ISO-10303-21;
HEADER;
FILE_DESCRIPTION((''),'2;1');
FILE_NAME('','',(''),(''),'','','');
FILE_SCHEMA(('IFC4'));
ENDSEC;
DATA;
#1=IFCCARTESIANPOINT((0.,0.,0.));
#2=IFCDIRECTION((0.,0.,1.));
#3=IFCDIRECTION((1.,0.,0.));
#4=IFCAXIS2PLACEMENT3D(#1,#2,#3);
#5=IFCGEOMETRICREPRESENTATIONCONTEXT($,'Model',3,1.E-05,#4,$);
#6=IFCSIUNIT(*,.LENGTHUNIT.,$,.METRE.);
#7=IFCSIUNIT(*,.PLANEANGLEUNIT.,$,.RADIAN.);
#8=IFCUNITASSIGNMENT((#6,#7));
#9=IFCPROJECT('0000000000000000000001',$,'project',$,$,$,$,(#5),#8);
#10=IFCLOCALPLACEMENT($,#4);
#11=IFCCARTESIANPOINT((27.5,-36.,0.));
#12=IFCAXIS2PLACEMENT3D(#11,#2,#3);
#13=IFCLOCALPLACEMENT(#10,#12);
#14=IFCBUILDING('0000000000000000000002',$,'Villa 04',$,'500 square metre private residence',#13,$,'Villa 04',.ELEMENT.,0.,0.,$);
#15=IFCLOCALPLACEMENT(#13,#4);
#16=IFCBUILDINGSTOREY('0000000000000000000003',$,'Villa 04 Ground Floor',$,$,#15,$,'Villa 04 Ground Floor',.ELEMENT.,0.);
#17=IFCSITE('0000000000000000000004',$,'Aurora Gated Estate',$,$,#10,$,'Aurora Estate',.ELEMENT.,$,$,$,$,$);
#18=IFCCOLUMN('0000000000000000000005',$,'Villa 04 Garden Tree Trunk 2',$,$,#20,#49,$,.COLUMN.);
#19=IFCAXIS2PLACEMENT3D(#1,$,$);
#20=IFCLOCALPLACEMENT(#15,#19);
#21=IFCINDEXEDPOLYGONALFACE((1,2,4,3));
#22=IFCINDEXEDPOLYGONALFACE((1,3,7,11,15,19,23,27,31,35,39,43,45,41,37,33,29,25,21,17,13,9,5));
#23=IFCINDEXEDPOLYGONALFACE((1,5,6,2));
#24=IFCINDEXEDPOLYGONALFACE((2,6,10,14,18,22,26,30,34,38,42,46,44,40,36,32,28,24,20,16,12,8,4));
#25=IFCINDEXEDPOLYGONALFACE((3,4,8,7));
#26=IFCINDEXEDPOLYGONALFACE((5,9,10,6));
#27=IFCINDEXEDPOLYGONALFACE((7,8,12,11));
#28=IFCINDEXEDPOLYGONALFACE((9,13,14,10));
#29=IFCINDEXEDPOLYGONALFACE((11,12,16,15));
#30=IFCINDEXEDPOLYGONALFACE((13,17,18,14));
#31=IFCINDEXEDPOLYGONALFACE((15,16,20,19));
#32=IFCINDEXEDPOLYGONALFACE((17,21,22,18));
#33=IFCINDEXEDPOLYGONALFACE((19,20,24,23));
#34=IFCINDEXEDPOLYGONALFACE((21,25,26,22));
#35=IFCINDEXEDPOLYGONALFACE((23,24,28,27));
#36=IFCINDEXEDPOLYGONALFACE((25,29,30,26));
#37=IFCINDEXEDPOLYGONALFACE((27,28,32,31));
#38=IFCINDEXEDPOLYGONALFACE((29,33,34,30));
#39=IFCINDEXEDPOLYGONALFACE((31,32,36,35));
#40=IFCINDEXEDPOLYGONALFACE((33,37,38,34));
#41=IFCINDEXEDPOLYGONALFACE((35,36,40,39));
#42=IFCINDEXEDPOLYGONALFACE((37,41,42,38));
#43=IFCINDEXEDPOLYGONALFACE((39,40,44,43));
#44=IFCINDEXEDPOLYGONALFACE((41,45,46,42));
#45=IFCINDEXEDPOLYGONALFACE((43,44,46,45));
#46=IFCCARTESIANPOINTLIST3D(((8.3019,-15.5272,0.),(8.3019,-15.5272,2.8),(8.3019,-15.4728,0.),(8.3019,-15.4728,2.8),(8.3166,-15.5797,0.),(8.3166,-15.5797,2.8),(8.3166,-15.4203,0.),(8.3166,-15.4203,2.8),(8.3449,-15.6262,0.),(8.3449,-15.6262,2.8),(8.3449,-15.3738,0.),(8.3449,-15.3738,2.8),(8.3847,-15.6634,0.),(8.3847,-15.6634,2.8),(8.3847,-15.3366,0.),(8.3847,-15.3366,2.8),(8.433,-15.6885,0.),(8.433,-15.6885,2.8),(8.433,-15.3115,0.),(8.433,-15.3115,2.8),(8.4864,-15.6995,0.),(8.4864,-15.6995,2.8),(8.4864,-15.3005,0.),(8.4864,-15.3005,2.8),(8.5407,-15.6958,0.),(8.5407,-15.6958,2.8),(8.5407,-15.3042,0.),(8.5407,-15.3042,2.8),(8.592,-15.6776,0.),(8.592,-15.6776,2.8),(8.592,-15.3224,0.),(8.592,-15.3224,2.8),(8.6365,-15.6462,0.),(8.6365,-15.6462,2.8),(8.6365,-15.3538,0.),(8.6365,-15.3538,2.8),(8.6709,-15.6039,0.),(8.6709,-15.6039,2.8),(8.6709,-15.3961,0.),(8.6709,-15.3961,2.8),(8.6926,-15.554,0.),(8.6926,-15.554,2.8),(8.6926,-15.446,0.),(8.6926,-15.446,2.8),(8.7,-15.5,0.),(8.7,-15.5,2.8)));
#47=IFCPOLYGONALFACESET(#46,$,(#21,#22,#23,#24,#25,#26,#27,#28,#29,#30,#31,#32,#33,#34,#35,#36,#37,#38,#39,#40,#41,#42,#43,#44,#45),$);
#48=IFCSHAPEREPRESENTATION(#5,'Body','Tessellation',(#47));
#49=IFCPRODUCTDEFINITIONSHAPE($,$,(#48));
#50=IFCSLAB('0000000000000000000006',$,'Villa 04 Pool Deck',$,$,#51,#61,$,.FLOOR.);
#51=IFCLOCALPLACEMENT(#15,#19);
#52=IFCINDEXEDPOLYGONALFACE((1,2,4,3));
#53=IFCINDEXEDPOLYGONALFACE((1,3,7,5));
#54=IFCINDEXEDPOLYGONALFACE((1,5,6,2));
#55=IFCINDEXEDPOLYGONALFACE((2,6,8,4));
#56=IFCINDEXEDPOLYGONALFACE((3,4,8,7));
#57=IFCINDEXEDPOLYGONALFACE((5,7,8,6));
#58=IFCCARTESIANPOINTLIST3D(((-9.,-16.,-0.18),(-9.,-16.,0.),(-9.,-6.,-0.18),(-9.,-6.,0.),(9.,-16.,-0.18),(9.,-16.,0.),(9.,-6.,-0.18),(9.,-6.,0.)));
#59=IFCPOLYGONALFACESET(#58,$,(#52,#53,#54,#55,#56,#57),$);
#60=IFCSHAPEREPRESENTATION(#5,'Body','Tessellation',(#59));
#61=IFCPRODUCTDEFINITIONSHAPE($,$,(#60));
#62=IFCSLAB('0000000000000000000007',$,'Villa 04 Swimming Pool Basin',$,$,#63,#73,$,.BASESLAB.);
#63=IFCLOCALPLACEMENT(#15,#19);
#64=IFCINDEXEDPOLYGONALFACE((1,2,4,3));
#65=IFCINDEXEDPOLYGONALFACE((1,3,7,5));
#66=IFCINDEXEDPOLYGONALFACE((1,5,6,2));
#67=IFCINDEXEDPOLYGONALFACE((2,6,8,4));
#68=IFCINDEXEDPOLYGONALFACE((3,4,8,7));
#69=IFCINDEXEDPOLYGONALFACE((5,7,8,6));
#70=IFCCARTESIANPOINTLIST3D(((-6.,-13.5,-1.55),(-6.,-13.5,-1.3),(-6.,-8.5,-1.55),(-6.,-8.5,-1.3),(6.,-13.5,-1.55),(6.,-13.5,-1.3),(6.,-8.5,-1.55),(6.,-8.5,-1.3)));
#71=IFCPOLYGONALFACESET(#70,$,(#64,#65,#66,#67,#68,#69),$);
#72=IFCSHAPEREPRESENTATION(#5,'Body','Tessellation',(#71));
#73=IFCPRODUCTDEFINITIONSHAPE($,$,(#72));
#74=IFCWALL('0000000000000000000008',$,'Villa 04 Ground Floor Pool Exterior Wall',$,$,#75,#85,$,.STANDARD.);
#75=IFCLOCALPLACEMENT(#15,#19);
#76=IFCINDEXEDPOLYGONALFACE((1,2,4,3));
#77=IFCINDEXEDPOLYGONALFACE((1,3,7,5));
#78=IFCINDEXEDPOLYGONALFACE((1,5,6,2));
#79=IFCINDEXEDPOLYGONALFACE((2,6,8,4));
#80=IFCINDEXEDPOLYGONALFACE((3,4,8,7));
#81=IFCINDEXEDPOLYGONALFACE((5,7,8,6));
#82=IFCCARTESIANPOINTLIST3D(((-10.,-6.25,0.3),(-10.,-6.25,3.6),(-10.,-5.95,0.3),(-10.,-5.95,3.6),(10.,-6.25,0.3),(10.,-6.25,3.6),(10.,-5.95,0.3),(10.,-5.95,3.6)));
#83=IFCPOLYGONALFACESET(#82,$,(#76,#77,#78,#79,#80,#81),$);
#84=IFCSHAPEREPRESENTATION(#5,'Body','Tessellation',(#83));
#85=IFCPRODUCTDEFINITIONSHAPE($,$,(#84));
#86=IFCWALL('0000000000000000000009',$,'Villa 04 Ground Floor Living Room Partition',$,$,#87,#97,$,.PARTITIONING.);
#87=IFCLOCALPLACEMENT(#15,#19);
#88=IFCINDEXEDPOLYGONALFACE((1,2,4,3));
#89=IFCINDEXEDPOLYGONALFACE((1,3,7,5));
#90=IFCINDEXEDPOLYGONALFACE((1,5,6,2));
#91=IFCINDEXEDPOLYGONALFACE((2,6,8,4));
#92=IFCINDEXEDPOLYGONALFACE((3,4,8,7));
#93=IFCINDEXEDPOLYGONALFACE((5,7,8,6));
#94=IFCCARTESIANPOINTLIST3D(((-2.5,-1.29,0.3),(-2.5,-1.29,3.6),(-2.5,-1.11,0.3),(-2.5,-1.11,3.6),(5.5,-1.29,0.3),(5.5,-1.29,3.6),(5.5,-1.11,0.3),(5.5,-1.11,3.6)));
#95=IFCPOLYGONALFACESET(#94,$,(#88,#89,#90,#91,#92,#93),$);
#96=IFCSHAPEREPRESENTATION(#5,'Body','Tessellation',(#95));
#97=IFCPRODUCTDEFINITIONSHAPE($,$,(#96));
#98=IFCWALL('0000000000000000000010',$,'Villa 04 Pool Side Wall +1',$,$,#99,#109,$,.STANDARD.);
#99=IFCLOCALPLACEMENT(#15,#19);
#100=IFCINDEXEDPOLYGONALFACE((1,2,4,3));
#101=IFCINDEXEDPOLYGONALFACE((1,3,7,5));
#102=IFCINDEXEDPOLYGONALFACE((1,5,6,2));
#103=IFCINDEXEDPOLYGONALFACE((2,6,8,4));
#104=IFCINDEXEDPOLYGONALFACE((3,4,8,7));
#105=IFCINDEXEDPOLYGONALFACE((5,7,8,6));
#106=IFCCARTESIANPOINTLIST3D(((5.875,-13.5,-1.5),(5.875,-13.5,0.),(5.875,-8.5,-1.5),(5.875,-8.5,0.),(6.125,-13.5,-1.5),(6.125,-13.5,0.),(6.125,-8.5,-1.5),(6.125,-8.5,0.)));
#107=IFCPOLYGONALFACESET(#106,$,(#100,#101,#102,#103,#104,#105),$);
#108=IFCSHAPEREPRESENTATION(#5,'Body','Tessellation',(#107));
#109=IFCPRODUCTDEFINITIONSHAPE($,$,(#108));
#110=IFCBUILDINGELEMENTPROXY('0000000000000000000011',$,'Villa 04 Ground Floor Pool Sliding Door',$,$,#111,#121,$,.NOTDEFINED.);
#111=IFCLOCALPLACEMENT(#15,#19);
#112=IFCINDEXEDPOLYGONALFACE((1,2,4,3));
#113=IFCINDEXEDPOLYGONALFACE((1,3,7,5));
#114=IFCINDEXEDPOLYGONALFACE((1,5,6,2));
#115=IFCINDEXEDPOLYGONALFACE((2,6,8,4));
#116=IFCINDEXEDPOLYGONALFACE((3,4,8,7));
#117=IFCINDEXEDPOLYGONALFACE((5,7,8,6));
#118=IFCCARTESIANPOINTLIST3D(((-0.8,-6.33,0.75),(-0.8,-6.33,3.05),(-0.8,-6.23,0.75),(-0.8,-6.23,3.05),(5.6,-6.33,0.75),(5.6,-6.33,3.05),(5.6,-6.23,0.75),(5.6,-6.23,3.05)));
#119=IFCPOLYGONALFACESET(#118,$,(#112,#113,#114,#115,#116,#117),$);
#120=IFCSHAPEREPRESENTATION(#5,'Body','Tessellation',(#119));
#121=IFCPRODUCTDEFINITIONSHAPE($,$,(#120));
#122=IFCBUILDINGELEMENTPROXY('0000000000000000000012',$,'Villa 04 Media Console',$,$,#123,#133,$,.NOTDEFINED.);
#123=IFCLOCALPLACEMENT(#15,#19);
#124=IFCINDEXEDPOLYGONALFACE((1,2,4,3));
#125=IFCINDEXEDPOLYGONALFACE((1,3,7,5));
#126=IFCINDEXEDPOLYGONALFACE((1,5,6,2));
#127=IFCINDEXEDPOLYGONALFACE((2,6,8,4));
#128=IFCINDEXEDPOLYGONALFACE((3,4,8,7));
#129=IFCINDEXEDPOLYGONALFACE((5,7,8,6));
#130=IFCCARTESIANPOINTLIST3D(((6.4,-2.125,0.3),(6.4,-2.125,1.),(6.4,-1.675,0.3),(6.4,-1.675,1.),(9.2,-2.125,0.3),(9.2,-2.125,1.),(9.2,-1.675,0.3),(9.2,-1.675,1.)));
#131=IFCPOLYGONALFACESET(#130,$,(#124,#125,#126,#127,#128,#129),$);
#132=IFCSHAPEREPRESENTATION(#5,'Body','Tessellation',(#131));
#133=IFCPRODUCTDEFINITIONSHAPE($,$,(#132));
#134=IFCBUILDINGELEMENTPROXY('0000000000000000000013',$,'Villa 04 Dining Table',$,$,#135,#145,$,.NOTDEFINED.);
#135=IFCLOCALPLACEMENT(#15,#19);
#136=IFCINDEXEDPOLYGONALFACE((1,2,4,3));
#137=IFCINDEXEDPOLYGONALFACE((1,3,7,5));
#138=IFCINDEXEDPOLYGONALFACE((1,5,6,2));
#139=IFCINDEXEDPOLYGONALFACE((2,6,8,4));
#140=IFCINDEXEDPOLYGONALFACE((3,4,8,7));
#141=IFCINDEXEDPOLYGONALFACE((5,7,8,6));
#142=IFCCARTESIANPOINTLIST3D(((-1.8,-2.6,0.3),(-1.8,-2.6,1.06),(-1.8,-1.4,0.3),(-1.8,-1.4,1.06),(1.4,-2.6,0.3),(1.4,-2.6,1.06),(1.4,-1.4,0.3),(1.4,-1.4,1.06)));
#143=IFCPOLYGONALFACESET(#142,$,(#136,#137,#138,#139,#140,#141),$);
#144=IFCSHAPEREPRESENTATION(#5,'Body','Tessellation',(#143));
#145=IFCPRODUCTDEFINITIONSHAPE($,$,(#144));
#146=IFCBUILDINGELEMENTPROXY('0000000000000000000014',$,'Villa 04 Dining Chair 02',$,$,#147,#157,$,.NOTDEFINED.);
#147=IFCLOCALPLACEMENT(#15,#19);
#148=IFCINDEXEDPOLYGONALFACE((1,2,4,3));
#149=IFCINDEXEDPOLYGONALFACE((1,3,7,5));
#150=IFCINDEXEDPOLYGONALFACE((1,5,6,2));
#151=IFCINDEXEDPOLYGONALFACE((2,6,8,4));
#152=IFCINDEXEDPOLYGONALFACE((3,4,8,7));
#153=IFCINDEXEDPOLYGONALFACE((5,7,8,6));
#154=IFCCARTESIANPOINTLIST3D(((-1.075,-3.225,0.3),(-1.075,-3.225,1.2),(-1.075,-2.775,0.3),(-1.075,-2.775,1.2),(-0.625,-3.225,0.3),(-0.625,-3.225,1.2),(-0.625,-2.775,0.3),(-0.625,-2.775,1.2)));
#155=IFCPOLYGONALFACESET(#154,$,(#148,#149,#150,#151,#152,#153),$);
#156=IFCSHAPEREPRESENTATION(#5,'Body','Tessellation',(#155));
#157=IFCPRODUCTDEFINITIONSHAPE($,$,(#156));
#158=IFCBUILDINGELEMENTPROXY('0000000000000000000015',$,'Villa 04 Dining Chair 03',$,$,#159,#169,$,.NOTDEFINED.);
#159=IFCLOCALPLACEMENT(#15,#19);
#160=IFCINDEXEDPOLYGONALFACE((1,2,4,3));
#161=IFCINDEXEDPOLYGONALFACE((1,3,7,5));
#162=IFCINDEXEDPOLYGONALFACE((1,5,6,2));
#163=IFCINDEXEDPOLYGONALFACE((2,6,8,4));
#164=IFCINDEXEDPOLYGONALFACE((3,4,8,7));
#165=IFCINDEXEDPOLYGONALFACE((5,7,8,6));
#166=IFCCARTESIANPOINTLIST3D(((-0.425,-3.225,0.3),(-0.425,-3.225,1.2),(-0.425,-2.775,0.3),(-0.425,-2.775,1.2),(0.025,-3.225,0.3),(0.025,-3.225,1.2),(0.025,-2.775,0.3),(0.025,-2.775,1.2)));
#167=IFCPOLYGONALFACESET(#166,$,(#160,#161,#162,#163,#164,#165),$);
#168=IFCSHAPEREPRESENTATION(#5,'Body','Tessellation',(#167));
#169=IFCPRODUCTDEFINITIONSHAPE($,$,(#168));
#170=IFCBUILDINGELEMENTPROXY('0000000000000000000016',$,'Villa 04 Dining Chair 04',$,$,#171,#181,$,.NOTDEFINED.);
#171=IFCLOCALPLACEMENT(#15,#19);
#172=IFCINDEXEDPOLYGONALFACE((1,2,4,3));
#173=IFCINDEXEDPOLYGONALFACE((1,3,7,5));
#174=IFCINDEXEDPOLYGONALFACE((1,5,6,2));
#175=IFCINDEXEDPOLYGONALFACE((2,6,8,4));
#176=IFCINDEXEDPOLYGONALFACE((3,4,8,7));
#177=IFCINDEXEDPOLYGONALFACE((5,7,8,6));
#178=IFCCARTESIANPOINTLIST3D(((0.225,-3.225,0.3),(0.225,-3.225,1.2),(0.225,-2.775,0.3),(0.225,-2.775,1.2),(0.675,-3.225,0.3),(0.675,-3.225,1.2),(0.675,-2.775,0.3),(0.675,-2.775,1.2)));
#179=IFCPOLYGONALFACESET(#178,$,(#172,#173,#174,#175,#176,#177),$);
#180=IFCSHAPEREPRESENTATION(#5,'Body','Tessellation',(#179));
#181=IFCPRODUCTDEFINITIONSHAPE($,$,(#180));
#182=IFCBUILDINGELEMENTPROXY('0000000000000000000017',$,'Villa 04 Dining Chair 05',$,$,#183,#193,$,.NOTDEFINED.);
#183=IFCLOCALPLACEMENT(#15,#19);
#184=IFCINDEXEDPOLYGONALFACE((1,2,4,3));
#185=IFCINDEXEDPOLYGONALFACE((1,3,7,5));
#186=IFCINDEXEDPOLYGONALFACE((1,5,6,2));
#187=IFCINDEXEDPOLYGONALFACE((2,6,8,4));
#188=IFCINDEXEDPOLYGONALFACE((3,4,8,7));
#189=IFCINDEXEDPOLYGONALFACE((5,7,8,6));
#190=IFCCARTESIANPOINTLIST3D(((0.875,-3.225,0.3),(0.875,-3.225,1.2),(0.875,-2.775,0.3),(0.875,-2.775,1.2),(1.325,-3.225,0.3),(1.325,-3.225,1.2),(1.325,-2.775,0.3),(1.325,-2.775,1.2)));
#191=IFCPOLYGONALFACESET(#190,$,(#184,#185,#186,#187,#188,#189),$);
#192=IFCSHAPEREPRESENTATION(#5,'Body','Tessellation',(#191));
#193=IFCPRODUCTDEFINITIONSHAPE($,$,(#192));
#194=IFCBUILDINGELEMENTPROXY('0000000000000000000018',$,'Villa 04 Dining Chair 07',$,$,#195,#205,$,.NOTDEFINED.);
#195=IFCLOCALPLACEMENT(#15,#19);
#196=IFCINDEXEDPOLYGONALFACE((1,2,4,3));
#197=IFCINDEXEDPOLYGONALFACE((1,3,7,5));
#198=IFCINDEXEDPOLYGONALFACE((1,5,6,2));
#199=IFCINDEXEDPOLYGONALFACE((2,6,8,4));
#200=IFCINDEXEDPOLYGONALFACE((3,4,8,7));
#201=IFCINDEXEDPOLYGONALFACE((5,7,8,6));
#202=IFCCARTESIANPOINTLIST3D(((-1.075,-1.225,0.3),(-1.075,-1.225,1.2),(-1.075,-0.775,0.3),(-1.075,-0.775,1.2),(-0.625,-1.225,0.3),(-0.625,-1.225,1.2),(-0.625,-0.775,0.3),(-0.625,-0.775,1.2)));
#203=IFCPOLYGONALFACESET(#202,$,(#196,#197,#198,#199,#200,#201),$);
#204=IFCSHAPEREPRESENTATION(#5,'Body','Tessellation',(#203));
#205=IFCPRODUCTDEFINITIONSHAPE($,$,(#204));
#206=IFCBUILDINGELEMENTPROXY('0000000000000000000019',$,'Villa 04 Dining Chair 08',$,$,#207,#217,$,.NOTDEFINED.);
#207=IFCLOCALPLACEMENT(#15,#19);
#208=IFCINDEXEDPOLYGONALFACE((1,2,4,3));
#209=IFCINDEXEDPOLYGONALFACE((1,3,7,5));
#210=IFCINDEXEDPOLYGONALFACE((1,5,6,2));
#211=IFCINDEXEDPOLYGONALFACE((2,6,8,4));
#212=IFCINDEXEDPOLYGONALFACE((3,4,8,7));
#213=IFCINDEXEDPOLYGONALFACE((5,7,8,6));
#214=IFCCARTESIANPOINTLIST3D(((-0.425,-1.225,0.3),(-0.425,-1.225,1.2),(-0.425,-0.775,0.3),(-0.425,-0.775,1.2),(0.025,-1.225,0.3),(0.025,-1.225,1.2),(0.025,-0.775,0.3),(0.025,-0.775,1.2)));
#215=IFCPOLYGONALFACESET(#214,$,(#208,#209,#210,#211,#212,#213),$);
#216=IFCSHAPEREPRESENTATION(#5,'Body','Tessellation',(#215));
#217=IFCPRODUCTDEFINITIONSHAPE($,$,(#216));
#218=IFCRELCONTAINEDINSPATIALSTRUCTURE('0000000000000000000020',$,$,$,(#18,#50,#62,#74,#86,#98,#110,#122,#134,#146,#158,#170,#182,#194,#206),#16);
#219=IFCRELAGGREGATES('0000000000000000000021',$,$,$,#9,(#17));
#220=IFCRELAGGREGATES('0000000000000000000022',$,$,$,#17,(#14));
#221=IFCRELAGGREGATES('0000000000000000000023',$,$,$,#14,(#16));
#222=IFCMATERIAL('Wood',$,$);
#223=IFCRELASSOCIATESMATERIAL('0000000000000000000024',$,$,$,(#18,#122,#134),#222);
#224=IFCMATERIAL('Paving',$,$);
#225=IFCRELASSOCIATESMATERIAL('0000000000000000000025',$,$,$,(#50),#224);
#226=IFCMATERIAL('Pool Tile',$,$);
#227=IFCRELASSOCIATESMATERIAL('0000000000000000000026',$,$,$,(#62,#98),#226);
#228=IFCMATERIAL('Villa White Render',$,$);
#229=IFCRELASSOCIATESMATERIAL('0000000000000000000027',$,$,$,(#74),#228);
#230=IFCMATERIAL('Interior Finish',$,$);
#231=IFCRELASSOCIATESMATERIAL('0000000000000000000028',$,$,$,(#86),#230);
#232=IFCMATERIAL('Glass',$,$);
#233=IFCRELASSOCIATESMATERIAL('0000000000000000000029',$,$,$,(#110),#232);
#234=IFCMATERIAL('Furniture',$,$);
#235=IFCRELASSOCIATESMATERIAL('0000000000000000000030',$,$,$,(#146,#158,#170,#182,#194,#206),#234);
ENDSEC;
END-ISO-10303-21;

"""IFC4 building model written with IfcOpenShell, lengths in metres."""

from ifc_helpers import new_model, si_unit, frame, origin_with_axes, origin_2d_with_axis, place, context, project, spatial, rectangle, circle, extrude, material, element, save


model = new_model("IFC4")

# Units and contexts
model_context = context("Model", 3, precision=1e-05, world=origin_with_axes())
ifc_project = project(units=[si_unit("LENGTHUNIT", "METRE"), si_unit("PLANEANGLEUNIT", "RADIAN")], contexts=[model_context])

# Site, building, storey
site_placement = place(None, origin_with_axes())
site = spatial("IfcSite", under=ifc_project, at=site_placement, Name="Aurora Gated Estate", LongName="Aurora Estate", CompositionType="ELEMENT")
building_placement = place(site_placement, frame((27.5, -36.0, 0.0), z_axis=(0.0, 0.0, 1.0), x_axis=(1.0, 0.0, 0.0)))
building = spatial("IfcBuilding", under=site, at=building_placement, Name="Villa 04", ObjectType="500 square metre private residence", LongName="Villa 04", CompositionType="ELEMENT", ElevationOfRefHeight=0.0, ElevationOfTerrain=0.0)
storey_placement = place(building_placement, origin_with_axes())
storey = spatial("IfcBuildingStorey", under=building, at=storey_placement, Name="Villa 04 Ground Floor", LongName="Villa 04 Ground Floor", CompositionType="ELEMENT", Elevation=0.0)

# Column
ifc_material_1 = material(Name="Wood")
column_placement = place(storey_placement, frame((8.5, -15.5, 0.0), z_axis=(0.0, 0.0, 1.0), x_axis=(1.0, 0.0, 0.0)))
element("IfcColumn", 1, at=column_placement, inside=storey, material=ifc_material_1, Name="Villa 04 Garden Tree Trunk 2", PredefinedType="COLUMN", context=model_context, shape_type="SweptSolid", body=[
    extrude(circle(Radius=0.2, at=origin_2d_with_axis()), origin_with_axes(), (0.0, 0.0, 1.0), 2.8),
])

# Slabs
ifc_material_2 = material(Name="Paving")
slab_1_placement = place(storey_placement, frame((0.0, -11.0, -0.18), z_axis=(0.0, 0.0, 1.0), x_axis=(1.0, 0.0, 0.0)))
element("IfcSlab", 2, at=slab_1_placement, inside=storey, material=ifc_material_2, Name="Villa 04 Pool Deck", PredefinedType="FLOOR", context=model_context, shape_type="SweptSolid", body=[
    extrude(rectangle(XDim=18.0, YDim=10.0, at=origin_2d_with_axis()), origin_with_axes(), (0.0, 0.0, 1.0), 0.18),
])
ifc_material_3 = material(Name="Pool Tile")
slab_2_placement = place(storey_placement, frame((0.0, -11.0, -1.55), z_axis=(0.0, 0.0, 1.0), x_axis=(1.0, 0.0, 0.0)))
element("IfcSlab", 3, at=slab_2_placement, inside=storey, material=ifc_material_3, Name="Villa 04 Swimming Pool Basin", PredefinedType="BASESLAB", context=model_context, shape_type="SweptSolid", body=[
    extrude(rectangle(XDim=12.0, YDim=5.0, at=origin_2d_with_axis()), origin_with_axes(), (0.0, 0.0, 1.0), 0.25),
])

# Walls
ifc_material_4 = material(Name="Villa White Render")
wall_1_placement = place(storey_placement, frame((0.0, -6.1, 0.3), z_axis=(0.0, 0.0, 1.0), x_axis=(1.0, 0.0, 0.0)))
element("IfcWall", 4, at=wall_1_placement, inside=storey, material=ifc_material_4, Name="Villa 04 Ground Floor Pool Exterior Wall", PredefinedType="STANDARD", context=model_context, shape_type="SweptSolid", body=[
    extrude(rectangle(XDim=20.0, YDim=0.3, at=origin_2d_with_axis()), origin_with_axes(), (0.0, 0.0, 1.0), 3.3),
])
ifc_material_5 = material(Name="Interior Finish")
wall_2_placement = place(storey_placement, frame((1.5, -1.2, 0.3), z_axis=(0.0, 0.0, 1.0), x_axis=(1.0, 0.0, 0.0)))
element("IfcWall", 5, at=wall_2_placement, inside=storey, material=ifc_material_5, Name="Villa 04 Ground Floor Living Room Partition", PredefinedType="PARTITIONING", context=model_context, shape_type="SweptSolid", body=[
    extrude(rectangle(XDim=8.0, YDim=0.18, at=origin_2d_with_axis()), origin_with_axes(), (0.0, 0.0, 1.0), 3.3),
])
wall_3_placement = place(storey_placement, frame((6.0, -11.0, -1.5), z_axis=(0.0, 0.0, 1.0), x_axis=(1.0, 0.0, 0.0)))
element("IfcWall", 6, at=wall_3_placement, inside=storey, material=ifc_material_3, Name="Villa 04 Pool Side Wall +1", PredefinedType="STANDARD", context=model_context, shape_type="SweptSolid", body=[
    extrude(rectangle(XDim=0.25, YDim=5.0, at=origin_2d_with_axis()), origin_with_axes(), (0.0, 0.0, 1.0), 1.5),
])

# Building element proxies
ifc_material_6 = material(Name="Glass")
proxy_1_placement = place(storey_placement, frame((2.4, -6.28, 0.75), z_axis=(0.0, 0.0, 1.0), x_axis=(1.0, 0.0, 0.0)))
element("IfcBuildingElementProxy", 7, at=proxy_1_placement, inside=storey, material=ifc_material_6, Name="Villa 04 Ground Floor Pool Sliding Door", PredefinedType="NOTDEFINED", context=model_context, shape_type="SweptSolid", body=[
    extrude(rectangle(XDim=6.4, YDim=0.1, at=origin_2d_with_axis()), origin_with_axes(), (0.0, 0.0, 1.0), 2.3),
])
proxy_2_placement = place(storey_placement, frame((7.8, -1.9, 0.3), z_axis=(0.0, 0.0, 1.0), x_axis=(1.0, 0.0, 0.0)))
element("IfcBuildingElementProxy", 8, at=proxy_2_placement, inside=storey, material=ifc_material_1, Name="Villa 04 Media Console", PredefinedType="NOTDEFINED", context=model_context, shape_type="SweptSolid", body=[
    extrude(rectangle(XDim=2.8, YDim=0.45, at=origin_2d_with_axis()), origin_with_axes(), (0.0, 0.0, 1.0), 0.7),
])
proxy_3_placement = place(storey_placement, frame((-0.2, -2.0, 0.3), z_axis=(0.0, 0.0, 1.0), x_axis=(1.0, 0.0, 0.0)))
element("IfcBuildingElementProxy", 9, at=proxy_3_placement, inside=storey, material=ifc_material_1, Name="Villa 04 Dining Table", PredefinedType="NOTDEFINED", context=model_context, shape_type="SweptSolid", body=[
    extrude(rectangle(XDim=3.2, YDim=1.2, at=origin_2d_with_axis()), origin_with_axes(), (0.0, 0.0, 1.0), 0.76),
])
ifc_material_7 = material(Name="Furniture")
for number, where, z_axis, x_axis, name in (
    (10, (-0.85, -3.0, 0.3), (0.0, 0.0, 1.0), (1.0, 0.0, 0.0), "Villa 04 Dining Chair 02"),
    (11, (-0.2, -3.0, 0.3), (0.0, 0.0, 1.0), (1.0, 0.0, 0.0), "Villa 04 Dining Chair 03"),
    (12, (0.45, -3.0, 0.3), (0.0, 0.0, 1.0), (1.0, 0.0, 0.0), "Villa 04 Dining Chair 04"),
    (13, (1.1, -3.0, 0.3), (0.0, 0.0, 1.0), (1.0, 0.0, 0.0), "Villa 04 Dining Chair 05"),
    (14, (-0.85, -1.0, 0.3), (0.0, 0.0, 1.0), (1.0, 0.0, 0.0), "Villa 04 Dining Chair 07"),
    (15, (-0.2, -1.0, 0.3), (0.0, 0.0, 1.0), (1.0, 0.0, 0.0), "Villa 04 Dining Chair 08"),
):
    element("IfcBuildingElementProxy", number, at=place(storey_placement, frame(where, z_axis=z_axis, x_axis=x_axis)), inside=storey, material=ifc_material_7, Name=name, PredefinedType="NOTDEFINED", context=model_context, shape_type="SweptSolid", body=[
        extrude(rectangle(XDim=0.45, YDim=0.45, at=origin_2d_with_axis()), origin_with_axes(), (0.0, 0.0, 1.0), 0.9),
    ])

save(model, "model.ifc")
